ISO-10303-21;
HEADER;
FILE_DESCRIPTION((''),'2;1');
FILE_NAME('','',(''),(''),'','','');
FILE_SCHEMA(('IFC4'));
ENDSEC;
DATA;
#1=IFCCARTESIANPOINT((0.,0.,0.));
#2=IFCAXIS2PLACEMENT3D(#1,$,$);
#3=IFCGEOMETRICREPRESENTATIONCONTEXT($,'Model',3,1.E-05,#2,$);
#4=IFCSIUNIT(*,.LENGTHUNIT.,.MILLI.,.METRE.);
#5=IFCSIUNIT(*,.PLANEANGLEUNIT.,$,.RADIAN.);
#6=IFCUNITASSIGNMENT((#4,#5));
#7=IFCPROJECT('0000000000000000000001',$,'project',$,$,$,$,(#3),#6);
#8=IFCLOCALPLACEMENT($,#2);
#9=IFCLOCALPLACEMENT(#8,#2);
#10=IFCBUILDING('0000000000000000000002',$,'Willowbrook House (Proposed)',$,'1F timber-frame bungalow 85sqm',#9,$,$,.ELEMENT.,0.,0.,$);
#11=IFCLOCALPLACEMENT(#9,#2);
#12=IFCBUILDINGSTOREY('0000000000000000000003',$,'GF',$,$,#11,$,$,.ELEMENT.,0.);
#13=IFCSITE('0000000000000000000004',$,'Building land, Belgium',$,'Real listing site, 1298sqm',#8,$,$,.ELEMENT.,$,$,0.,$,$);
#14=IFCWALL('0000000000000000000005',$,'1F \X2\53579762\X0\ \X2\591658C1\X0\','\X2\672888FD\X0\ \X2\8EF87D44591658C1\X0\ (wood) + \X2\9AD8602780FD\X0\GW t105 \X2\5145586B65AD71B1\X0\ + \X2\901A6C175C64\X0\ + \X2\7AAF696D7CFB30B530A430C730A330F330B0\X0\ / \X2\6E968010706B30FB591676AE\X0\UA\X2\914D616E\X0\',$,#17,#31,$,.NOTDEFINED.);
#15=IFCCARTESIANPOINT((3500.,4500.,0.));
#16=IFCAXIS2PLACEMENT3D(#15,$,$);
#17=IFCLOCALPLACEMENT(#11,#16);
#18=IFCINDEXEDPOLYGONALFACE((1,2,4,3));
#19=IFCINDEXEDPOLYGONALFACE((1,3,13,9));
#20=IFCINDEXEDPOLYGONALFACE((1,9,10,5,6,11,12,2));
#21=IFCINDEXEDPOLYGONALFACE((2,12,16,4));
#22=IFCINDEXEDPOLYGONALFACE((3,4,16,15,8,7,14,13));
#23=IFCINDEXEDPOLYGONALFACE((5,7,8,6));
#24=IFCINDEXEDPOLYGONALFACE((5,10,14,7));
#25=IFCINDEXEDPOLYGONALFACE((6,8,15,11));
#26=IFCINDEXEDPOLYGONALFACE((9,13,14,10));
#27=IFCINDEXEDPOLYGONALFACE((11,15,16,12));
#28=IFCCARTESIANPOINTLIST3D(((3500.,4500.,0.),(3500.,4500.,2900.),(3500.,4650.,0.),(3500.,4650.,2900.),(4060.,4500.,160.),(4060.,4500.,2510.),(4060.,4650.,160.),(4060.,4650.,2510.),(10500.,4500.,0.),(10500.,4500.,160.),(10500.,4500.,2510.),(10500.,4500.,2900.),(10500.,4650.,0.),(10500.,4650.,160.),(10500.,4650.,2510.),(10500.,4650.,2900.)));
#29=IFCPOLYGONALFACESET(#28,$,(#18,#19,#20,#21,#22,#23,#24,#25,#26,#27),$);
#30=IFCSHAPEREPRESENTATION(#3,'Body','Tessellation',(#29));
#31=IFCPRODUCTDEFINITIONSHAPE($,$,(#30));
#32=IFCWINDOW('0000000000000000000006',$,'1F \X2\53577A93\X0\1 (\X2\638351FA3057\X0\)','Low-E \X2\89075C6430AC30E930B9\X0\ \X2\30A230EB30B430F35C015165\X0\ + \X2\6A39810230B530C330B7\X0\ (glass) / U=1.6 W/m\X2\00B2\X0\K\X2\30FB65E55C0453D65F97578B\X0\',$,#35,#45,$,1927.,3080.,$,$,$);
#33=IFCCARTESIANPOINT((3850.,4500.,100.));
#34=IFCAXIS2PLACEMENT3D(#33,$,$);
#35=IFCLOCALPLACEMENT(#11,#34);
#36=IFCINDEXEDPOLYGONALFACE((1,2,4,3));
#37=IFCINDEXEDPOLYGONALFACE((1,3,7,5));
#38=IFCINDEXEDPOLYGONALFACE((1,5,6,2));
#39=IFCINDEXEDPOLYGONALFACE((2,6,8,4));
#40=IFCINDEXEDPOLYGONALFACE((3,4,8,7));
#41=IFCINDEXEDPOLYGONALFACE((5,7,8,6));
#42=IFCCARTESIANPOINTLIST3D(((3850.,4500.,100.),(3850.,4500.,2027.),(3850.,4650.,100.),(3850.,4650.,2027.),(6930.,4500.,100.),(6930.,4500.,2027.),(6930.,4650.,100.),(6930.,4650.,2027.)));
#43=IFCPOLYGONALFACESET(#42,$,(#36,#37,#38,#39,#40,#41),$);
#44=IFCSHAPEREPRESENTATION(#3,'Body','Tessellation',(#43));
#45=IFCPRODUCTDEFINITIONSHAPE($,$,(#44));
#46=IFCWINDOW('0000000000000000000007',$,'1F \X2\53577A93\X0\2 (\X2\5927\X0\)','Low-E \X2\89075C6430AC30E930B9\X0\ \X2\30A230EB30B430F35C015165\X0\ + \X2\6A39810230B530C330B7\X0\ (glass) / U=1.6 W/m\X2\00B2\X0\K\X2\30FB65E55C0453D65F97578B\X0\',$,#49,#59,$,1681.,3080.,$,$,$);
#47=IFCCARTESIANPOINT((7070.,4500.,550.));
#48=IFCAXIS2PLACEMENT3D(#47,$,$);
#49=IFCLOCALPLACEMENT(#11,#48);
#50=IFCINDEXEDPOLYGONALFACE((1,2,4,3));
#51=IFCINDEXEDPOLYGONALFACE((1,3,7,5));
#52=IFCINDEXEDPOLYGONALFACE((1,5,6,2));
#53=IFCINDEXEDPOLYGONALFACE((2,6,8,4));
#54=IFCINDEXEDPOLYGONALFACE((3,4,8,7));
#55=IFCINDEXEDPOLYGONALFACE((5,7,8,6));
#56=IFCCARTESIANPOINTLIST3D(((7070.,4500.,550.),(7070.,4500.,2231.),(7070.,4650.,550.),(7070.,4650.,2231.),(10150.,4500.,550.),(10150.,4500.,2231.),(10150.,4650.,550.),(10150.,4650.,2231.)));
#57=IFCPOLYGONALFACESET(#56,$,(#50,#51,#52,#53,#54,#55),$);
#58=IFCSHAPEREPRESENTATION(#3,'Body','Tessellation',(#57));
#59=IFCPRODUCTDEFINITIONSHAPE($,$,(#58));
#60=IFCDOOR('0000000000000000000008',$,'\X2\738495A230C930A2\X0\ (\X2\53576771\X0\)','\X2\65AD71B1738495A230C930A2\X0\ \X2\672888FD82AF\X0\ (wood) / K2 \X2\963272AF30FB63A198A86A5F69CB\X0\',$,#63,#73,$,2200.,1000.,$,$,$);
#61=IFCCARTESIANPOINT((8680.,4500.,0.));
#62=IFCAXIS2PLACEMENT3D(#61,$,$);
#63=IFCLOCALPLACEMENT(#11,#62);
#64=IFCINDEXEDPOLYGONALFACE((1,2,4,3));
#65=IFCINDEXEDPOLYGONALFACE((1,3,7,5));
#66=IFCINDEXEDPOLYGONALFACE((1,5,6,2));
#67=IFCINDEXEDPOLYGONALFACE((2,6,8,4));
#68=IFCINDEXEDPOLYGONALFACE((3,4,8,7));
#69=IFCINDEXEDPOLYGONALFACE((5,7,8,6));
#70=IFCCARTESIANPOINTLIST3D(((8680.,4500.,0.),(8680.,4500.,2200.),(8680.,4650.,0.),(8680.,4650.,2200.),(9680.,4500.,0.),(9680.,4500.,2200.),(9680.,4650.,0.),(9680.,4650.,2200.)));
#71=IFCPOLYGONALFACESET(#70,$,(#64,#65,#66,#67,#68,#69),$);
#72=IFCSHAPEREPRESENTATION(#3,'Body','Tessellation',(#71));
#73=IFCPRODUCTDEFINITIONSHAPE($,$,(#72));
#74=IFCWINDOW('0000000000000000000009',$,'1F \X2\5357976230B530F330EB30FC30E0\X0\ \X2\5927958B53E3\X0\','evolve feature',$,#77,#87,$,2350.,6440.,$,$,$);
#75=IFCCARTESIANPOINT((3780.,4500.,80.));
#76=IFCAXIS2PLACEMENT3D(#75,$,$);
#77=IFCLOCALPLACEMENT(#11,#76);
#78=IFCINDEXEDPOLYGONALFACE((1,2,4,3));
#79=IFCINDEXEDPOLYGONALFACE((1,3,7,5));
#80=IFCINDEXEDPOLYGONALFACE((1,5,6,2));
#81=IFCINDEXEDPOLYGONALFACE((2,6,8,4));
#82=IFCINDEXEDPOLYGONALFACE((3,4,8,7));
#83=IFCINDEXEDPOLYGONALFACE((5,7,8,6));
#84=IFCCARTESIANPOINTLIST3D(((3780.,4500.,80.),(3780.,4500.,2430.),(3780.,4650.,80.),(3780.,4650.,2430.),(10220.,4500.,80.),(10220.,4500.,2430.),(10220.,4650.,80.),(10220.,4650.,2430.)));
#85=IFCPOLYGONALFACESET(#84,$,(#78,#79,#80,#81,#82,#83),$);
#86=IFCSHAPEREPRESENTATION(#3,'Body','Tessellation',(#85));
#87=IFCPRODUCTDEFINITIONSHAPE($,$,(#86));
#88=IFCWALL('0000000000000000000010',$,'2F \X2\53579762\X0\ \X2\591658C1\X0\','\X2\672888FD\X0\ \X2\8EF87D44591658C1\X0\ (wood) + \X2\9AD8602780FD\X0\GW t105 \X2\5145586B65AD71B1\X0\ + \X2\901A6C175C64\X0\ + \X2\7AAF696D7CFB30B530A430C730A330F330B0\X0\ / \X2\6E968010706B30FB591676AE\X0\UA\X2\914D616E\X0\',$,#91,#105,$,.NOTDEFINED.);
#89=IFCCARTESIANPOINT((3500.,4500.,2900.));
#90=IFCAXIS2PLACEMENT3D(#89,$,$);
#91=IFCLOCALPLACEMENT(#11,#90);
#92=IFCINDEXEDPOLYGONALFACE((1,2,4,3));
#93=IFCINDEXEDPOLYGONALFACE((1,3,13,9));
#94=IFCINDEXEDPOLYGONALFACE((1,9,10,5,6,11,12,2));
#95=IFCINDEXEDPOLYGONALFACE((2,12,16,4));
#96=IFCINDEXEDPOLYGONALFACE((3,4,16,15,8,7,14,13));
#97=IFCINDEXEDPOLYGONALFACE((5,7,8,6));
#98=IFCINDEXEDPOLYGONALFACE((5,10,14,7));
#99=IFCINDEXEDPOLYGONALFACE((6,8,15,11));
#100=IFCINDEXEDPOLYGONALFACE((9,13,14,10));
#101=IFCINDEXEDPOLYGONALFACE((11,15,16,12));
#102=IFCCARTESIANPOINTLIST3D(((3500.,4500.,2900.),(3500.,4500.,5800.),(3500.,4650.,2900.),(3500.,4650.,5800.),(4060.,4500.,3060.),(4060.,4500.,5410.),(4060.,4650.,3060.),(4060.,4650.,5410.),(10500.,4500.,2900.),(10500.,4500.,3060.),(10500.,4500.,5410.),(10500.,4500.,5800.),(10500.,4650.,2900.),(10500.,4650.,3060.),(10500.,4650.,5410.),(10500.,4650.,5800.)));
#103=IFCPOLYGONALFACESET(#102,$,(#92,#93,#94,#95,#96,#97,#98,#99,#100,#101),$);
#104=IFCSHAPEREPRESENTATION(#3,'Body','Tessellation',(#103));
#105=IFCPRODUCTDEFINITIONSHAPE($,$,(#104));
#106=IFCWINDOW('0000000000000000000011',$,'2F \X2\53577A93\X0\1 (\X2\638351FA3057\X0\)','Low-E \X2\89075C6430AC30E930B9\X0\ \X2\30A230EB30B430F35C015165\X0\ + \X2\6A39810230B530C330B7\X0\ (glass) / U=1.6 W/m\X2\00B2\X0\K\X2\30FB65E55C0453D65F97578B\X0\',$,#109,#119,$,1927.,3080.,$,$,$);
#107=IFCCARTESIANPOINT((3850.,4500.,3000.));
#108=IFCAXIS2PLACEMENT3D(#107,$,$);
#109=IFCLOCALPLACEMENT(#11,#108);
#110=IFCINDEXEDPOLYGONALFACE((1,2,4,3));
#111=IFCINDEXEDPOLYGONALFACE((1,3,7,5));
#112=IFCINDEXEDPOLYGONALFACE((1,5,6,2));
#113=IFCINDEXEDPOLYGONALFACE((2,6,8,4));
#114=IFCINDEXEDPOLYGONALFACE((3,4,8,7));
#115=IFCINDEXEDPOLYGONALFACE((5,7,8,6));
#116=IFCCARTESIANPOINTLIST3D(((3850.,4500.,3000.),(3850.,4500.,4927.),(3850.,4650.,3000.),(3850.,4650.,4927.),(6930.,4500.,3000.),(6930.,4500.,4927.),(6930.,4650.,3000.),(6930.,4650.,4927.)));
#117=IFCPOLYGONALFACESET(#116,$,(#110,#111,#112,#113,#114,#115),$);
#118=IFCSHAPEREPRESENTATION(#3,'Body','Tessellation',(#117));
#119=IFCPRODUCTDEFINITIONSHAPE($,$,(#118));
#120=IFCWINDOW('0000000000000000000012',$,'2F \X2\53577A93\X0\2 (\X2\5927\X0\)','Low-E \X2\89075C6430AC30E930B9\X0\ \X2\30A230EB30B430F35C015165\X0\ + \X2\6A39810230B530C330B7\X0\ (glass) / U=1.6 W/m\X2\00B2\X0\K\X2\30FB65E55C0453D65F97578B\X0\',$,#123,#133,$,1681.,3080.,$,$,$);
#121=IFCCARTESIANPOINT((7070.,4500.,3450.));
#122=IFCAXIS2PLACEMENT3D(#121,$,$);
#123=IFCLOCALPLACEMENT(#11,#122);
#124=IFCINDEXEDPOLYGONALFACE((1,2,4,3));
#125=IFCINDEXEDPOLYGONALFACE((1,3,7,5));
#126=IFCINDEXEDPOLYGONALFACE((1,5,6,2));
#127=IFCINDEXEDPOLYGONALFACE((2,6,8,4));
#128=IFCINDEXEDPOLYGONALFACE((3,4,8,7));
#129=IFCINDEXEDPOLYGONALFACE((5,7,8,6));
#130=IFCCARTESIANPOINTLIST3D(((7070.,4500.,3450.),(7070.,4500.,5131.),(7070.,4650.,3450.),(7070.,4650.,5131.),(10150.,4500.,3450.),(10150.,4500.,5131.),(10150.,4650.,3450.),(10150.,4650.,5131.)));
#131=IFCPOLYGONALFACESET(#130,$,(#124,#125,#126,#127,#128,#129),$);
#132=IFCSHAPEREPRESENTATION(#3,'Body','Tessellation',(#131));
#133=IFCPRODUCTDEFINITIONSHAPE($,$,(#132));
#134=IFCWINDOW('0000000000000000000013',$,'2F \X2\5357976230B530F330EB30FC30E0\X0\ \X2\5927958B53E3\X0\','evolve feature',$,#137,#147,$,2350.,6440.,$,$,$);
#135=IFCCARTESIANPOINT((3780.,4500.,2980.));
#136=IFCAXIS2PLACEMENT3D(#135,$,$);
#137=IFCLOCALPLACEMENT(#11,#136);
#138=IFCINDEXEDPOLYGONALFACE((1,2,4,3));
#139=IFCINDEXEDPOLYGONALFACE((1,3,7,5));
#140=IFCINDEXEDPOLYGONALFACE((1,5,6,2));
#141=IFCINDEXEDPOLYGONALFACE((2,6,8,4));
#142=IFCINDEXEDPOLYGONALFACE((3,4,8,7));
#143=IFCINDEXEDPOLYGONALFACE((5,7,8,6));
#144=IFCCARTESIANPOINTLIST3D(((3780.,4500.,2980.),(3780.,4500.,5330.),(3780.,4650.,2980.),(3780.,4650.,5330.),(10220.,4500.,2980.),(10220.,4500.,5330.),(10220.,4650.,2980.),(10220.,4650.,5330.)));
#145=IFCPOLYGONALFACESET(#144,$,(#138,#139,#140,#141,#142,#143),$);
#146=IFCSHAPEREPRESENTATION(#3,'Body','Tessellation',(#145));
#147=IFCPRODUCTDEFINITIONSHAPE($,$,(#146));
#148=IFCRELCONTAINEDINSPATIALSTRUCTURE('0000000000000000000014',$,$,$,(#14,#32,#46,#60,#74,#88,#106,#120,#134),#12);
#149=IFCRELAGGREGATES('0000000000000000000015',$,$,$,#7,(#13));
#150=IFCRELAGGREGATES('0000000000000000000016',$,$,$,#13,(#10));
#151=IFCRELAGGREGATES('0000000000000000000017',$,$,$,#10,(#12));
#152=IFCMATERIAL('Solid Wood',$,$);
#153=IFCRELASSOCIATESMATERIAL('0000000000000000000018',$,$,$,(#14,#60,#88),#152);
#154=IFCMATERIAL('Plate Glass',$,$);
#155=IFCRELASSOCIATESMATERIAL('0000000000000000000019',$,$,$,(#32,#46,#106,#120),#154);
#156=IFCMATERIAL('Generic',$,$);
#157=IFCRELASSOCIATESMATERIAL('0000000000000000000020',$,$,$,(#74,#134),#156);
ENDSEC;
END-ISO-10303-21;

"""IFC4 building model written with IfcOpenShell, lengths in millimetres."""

from ifc_helpers import new_model, si_unit, frame, frame_2d, origin, place, context, project, spatial, rectangle, extrude, material, element, fill, save


model = new_model("IFC4")

# Units and contexts
model_context = context("Model", 3, precision=1e-05, world=origin())
ifc_project = project(units=[si_unit("LENGTHUNIT", "METRE", prefix="MILLI"), si_unit("PLANEANGLEUNIT", "RADIAN")], contexts=[model_context])

# Site, building, storey
site_placement = place(None, origin())
site = spatial("IfcSite", under=ifc_project, at=site_placement, Name="Building land, Belgium", ObjectType="Real listing site, 1298sqm", CompositionType="ELEMENT", RefElevation=0.0)
building_placement = place(site_placement, origin())
building = spatial("IfcBuilding", under=site, at=building_placement, Name="Willowbrook House (Proposed)", ObjectType="1F timber-frame bungalow 85sqm", CompositionType="ELEMENT", ElevationOfRefHeight=0.0, ElevationOfTerrain=0.0)
storey_placement = place(building_placement, origin())
storey = spatial("IfcBuildingStorey", under=building, at=storey_placement, Name="GF", CompositionType="ELEMENT", Elevation=0.0)

# Shared definitions
ifc_material_1 = material(Name="Solid Wood")
ifc_material_2 = material(Name="Generic")

# Wall, openings, windows, door
wall_1_placement = place(storey_placement, frame((3500.0, 4500.0, 0.0)))
wall_1 = element("IfcWall", 1, at=wall_1_placement, inside=storey, material=ifc_material_1, Name="1F 南面 外壁", Description="木製 軸組外壁 (wood) + 高性能GW t105 充填断熱 + 通気層 + 窯業系サイディング / 準耐火・外皮UA配慮", PredefinedType="NOTDEFINED", context=model_context, shape_type="SweptSolid", body=[
    extrude(rectangle(XDim=7000.0, YDim=150.0, at=frame_2d((3500.0, 75.0))), frame((3500.0, 4500.0, 0.0)), (0.0, 0.0, 1.0), 2900.0),
])
opening_1_placement = place(storey_placement, frame((3850.0, 4500.0, 100.0)))
opening_1 = element("IfcOpeningElement", 2, at=opening_1_placement, cuts=wall_1, PredefinedType="NOTDEFINED", context=model_context, shape_type="SweptSolid", body=[
    extrude(rectangle(XDim=3080.0, YDim=150.0, at=frame_2d((1540.0, 75.0))), frame((3850.0, 4500.0, 100.0)), (0.0, 0.0, 1.0), 1927.0),
])
opening_2_placement = place(storey_placement, frame((7070.0, 4500.0, 550.0)))
opening_2 = element("IfcOpeningElement", 3, at=opening_2_placement, cuts=wall_1, PredefinedType="NOTDEFINED", context=model_context, shape_type="SweptSolid", body=[
    extrude(rectangle(XDim=3080.0, YDim=150.0, at=frame_2d((1540.0, 75.0))), frame((7070.0, 4500.0, 550.0)), (0.0, 0.0, 1.0), 1681.0),
])
opening_3_placement = place(storey_placement, frame((8680.0, 4500.0, 0.0)))
opening_3 = element("IfcOpeningElement", 4, at=opening_3_placement, cuts=wall_1, PredefinedType="NOTDEFINED", context=model_context, shape_type="SweptSolid", body=[
    extrude(rectangle(XDim=1000.0, YDim=150.0, at=frame_2d((500.0, 75.0))), frame((8680.0, 4500.0, 0.0)), (0.0, 0.0, 1.0), 2200.0),
])
opening_4_placement = place(storey_placement, frame((3780.0, 4500.0, 80.0)))
opening_4 = element("IfcOpeningElement", 5, at=opening_4_placement, cuts=wall_1, PredefinedType="NOTDEFINED", context=model_context, shape_type="SweptSolid", body=[
    extrude(rectangle(XDim=6440.0, YDim=150.0, at=frame_2d((3220.0, 75.0))), frame((3780.0, 4500.0, 80.0)), (0.0, 0.0, 1.0), 2350.0),
])
ifc_material_3 = material(Name="Plate Glass")
window_1_placement = place(storey_placement, frame((3850.0, 4500.0, 100.0)))
window_1 = element("IfcWindow", 6, at=window_1_placement, inside=storey, material=ifc_material_3, Name="1F 南窓1 (掃出し)", Description="Low-E 複層ガラス アルゴン封入 + 樹脂サッシ (glass) / U=1.6 W/m²K・日射取得型", OverallHeight=1927.0, OverallWidth=3080.0, context=model_context, shape_type="SweptSolid", body=[
    extrude(rectangle(XDim=3080.0, YDim=150.0, at=frame_2d((1540.0, 75.0))), frame((3850.0, 4500.0, 100.0)), (0.0, 0.0, 1.0), 1927.0),
])
fill(opening_1, window_1)
window_2_placement = place(storey_placement, frame((7070.0, 4500.0, 550.0)))
window_2 = element("IfcWindow", 7, at=window_2_placement, inside=storey, material=ifc_material_3, Name="1F 南窓2 (大)", Description="Low-E 複層ガラス アルゴン封入 + 樹脂サッシ (glass) / U=1.6 W/m²K・日射取得型", OverallHeight=1681.0, OverallWidth=3080.0, context=model_context, shape_type="SweptSolid", body=[
    extrude(rectangle(XDim=3080.0, YDim=150.0, at=frame_2d((1540.0, 75.0))), frame((7070.0, 4500.0, 550.0)), (0.0, 0.0, 1.0), 1681.0),
])
fill(opening_2, window_2)
door_placement = place(storey_placement, frame((8680.0, 4500.0, 0.0)))
door = element("IfcDoor", 8, at=door_placement, inside=storey, material=ifc_material_1, Name="玄関ドア (南東)", Description="断熱玄関ドア 木製芯 (wood) / K2 防犯・採風機構", OverallHeight=2200.0, OverallWidth=1000.0, context=model_context, shape_type="SweptSolid", body=[
    extrude(rectangle(XDim=1000.0, YDim=150.0, at=frame_2d((500.0, 75.0))), frame((8680.0, 4500.0, 0.0)), (0.0, 0.0, 1.0), 2200.0),
])
fill(opening_3, door)
window_3_placement = place(storey_placement, frame((3780.0, 4500.0, 80.0)))
window_3 = element("IfcWindow", 9, at=window_3_placement, inside=storey, material=ifc_material_2, Name="1F 南面サンルーム 大開口", Description="evolve feature", OverallHeight=2350.0, OverallWidth=6440.0, context=model_context, shape_type="SweptSolid", body=[
    extrude(rectangle(XDim=6440.0, YDim=150.0, at=frame_2d((3220.0, 75.0))), frame((3780.0, 4500.0, 80.0)), (0.0, 0.0, 1.0), 2350.0),
])
fill(opening_4, window_3)

# Wall, openings, windows
wall_2_placement = place(storey_placement, frame((3500.0, 4500.0, 2900.0)))
wall_2 = element("IfcWall", 10, at=wall_2_placement, inside=storey, material=ifc_material_1, Name="2F 南面 外壁", Description="木製 軸組外壁 (wood) + 高性能GW t105 充填断熱 + 通気層 + 窯業系サイディング / 準耐火・外皮UA配慮", PredefinedType="NOTDEFINED", context=model_context, shape_type="SweptSolid", body=[
    extrude(rectangle(XDim=7000.0, YDim=150.0, at=frame_2d((3500.0, 75.0))), frame((3500.0, 4500.0, 2900.0)), (0.0, 0.0, 1.0), 2900.0),
])
opening_5_placement = place(storey_placement, frame((3850.0, 4500.0, 3000.0)))
opening_5 = element("IfcOpeningElement", 11, at=opening_5_placement, cuts=wall_2, PredefinedType="NOTDEFINED", context=model_context, shape_type="SweptSolid", body=[
    extrude(rectangle(XDim=3080.0, YDim=150.0, at=frame_2d((1540.0, 75.0))), frame((3850.0, 4500.0, 3000.0)), (0.0, 0.0, 1.0), 1927.0),
])
opening_6_placement = place(storey_placement, frame((7070.0, 4500.0, 3450.0)))
opening_6 = element("IfcOpeningElement", 12, at=opening_6_placement, cuts=wall_2, PredefinedType="NOTDEFINED", context=model_context, shape_type="SweptSolid", body=[
    extrude(rectangle(XDim=3080.0, YDim=150.0, at=frame_2d((1540.0, 75.0))), frame((7070.0, 4500.0, 3450.0)), (0.0, 0.0, 1.0), 1681.0),
])
opening_7_placement = place(storey_placement, frame((3780.0, 4500.0, 2980.0)))
opening_7 = element("IfcOpeningElement", 13, at=opening_7_placement, cuts=wall_2, PredefinedType="NOTDEFINED", context=model_context, shape_type="SweptSolid", body=[
    extrude(rectangle(XDim=6440.0, YDim=150.0, at=frame_2d((3220.0, 75.0))), frame((3780.0, 4500.0, 2980.0)), (0.0, 0.0, 1.0), 2350.0),
])
window_4_placement = place(storey_placement, frame((3850.0, 4500.0, 3000.0)))
window_4 = element("IfcWindow", 14, at=window_4_placement, inside=storey, material=ifc_material_3, Name="2F 南窓1 (掃出し)", Description="Low-E 複層ガラス アルゴン封入 + 樹脂サッシ (glass) / U=1.6 W/m²K・日射取得型", OverallHeight=1927.0, OverallWidth=3080.0, context=model_context, shape_type="SweptSolid", body=[
    extrude(rectangle(XDim=3080.0, YDim=150.0, at=frame_2d((1540.0, 75.0))), frame((3850.0, 4500.0, 3000.0)), (0.0, 0.0, 1.0), 1927.0),
])
fill(opening_5, window_4)
window_5_placement = place(storey_placement, frame((7070.0, 4500.0, 3450.0)))
window_5 = element("IfcWindow", 15, at=window_5_placement, inside=storey, material=ifc_material_3, Name="2F 南窓2 (大)", Description="Low-E 複層ガラス アルゴン封入 + 樹脂サッシ (glass) / U=1.6 W/m²K・日射取得型", OverallHeight=1681.0, OverallWidth=3080.0, context=model_context, shape_type="SweptSolid", body=[
    extrude(rectangle(XDim=3080.0, YDim=150.0, at=frame_2d((1540.0, 75.0))), frame((7070.0, 4500.0, 3450.0)), (0.0, 0.0, 1.0), 1681.0),
])
fill(opening_6, window_5)
window_6_placement = place(storey_placement, frame((3780.0, 4500.0, 2980.0)))
window_6 = element("IfcWindow", 16, at=window_6_placement, inside=storey, material=ifc_material_2, Name="2F 南面サンルーム 大開口", Description="evolve feature", OverallHeight=2350.0, OverallWidth=6440.0, context=model_context, shape_type="SweptSolid", body=[
    extrude(rectangle(XDim=6440.0, YDim=150.0, at=frame_2d((3220.0, 75.0))), frame((3780.0, 4500.0, 2980.0)), (0.0, 0.0, 1.0), 2350.0),
])
fill(opening_7, window_6)

save(model, "model.ifc")
